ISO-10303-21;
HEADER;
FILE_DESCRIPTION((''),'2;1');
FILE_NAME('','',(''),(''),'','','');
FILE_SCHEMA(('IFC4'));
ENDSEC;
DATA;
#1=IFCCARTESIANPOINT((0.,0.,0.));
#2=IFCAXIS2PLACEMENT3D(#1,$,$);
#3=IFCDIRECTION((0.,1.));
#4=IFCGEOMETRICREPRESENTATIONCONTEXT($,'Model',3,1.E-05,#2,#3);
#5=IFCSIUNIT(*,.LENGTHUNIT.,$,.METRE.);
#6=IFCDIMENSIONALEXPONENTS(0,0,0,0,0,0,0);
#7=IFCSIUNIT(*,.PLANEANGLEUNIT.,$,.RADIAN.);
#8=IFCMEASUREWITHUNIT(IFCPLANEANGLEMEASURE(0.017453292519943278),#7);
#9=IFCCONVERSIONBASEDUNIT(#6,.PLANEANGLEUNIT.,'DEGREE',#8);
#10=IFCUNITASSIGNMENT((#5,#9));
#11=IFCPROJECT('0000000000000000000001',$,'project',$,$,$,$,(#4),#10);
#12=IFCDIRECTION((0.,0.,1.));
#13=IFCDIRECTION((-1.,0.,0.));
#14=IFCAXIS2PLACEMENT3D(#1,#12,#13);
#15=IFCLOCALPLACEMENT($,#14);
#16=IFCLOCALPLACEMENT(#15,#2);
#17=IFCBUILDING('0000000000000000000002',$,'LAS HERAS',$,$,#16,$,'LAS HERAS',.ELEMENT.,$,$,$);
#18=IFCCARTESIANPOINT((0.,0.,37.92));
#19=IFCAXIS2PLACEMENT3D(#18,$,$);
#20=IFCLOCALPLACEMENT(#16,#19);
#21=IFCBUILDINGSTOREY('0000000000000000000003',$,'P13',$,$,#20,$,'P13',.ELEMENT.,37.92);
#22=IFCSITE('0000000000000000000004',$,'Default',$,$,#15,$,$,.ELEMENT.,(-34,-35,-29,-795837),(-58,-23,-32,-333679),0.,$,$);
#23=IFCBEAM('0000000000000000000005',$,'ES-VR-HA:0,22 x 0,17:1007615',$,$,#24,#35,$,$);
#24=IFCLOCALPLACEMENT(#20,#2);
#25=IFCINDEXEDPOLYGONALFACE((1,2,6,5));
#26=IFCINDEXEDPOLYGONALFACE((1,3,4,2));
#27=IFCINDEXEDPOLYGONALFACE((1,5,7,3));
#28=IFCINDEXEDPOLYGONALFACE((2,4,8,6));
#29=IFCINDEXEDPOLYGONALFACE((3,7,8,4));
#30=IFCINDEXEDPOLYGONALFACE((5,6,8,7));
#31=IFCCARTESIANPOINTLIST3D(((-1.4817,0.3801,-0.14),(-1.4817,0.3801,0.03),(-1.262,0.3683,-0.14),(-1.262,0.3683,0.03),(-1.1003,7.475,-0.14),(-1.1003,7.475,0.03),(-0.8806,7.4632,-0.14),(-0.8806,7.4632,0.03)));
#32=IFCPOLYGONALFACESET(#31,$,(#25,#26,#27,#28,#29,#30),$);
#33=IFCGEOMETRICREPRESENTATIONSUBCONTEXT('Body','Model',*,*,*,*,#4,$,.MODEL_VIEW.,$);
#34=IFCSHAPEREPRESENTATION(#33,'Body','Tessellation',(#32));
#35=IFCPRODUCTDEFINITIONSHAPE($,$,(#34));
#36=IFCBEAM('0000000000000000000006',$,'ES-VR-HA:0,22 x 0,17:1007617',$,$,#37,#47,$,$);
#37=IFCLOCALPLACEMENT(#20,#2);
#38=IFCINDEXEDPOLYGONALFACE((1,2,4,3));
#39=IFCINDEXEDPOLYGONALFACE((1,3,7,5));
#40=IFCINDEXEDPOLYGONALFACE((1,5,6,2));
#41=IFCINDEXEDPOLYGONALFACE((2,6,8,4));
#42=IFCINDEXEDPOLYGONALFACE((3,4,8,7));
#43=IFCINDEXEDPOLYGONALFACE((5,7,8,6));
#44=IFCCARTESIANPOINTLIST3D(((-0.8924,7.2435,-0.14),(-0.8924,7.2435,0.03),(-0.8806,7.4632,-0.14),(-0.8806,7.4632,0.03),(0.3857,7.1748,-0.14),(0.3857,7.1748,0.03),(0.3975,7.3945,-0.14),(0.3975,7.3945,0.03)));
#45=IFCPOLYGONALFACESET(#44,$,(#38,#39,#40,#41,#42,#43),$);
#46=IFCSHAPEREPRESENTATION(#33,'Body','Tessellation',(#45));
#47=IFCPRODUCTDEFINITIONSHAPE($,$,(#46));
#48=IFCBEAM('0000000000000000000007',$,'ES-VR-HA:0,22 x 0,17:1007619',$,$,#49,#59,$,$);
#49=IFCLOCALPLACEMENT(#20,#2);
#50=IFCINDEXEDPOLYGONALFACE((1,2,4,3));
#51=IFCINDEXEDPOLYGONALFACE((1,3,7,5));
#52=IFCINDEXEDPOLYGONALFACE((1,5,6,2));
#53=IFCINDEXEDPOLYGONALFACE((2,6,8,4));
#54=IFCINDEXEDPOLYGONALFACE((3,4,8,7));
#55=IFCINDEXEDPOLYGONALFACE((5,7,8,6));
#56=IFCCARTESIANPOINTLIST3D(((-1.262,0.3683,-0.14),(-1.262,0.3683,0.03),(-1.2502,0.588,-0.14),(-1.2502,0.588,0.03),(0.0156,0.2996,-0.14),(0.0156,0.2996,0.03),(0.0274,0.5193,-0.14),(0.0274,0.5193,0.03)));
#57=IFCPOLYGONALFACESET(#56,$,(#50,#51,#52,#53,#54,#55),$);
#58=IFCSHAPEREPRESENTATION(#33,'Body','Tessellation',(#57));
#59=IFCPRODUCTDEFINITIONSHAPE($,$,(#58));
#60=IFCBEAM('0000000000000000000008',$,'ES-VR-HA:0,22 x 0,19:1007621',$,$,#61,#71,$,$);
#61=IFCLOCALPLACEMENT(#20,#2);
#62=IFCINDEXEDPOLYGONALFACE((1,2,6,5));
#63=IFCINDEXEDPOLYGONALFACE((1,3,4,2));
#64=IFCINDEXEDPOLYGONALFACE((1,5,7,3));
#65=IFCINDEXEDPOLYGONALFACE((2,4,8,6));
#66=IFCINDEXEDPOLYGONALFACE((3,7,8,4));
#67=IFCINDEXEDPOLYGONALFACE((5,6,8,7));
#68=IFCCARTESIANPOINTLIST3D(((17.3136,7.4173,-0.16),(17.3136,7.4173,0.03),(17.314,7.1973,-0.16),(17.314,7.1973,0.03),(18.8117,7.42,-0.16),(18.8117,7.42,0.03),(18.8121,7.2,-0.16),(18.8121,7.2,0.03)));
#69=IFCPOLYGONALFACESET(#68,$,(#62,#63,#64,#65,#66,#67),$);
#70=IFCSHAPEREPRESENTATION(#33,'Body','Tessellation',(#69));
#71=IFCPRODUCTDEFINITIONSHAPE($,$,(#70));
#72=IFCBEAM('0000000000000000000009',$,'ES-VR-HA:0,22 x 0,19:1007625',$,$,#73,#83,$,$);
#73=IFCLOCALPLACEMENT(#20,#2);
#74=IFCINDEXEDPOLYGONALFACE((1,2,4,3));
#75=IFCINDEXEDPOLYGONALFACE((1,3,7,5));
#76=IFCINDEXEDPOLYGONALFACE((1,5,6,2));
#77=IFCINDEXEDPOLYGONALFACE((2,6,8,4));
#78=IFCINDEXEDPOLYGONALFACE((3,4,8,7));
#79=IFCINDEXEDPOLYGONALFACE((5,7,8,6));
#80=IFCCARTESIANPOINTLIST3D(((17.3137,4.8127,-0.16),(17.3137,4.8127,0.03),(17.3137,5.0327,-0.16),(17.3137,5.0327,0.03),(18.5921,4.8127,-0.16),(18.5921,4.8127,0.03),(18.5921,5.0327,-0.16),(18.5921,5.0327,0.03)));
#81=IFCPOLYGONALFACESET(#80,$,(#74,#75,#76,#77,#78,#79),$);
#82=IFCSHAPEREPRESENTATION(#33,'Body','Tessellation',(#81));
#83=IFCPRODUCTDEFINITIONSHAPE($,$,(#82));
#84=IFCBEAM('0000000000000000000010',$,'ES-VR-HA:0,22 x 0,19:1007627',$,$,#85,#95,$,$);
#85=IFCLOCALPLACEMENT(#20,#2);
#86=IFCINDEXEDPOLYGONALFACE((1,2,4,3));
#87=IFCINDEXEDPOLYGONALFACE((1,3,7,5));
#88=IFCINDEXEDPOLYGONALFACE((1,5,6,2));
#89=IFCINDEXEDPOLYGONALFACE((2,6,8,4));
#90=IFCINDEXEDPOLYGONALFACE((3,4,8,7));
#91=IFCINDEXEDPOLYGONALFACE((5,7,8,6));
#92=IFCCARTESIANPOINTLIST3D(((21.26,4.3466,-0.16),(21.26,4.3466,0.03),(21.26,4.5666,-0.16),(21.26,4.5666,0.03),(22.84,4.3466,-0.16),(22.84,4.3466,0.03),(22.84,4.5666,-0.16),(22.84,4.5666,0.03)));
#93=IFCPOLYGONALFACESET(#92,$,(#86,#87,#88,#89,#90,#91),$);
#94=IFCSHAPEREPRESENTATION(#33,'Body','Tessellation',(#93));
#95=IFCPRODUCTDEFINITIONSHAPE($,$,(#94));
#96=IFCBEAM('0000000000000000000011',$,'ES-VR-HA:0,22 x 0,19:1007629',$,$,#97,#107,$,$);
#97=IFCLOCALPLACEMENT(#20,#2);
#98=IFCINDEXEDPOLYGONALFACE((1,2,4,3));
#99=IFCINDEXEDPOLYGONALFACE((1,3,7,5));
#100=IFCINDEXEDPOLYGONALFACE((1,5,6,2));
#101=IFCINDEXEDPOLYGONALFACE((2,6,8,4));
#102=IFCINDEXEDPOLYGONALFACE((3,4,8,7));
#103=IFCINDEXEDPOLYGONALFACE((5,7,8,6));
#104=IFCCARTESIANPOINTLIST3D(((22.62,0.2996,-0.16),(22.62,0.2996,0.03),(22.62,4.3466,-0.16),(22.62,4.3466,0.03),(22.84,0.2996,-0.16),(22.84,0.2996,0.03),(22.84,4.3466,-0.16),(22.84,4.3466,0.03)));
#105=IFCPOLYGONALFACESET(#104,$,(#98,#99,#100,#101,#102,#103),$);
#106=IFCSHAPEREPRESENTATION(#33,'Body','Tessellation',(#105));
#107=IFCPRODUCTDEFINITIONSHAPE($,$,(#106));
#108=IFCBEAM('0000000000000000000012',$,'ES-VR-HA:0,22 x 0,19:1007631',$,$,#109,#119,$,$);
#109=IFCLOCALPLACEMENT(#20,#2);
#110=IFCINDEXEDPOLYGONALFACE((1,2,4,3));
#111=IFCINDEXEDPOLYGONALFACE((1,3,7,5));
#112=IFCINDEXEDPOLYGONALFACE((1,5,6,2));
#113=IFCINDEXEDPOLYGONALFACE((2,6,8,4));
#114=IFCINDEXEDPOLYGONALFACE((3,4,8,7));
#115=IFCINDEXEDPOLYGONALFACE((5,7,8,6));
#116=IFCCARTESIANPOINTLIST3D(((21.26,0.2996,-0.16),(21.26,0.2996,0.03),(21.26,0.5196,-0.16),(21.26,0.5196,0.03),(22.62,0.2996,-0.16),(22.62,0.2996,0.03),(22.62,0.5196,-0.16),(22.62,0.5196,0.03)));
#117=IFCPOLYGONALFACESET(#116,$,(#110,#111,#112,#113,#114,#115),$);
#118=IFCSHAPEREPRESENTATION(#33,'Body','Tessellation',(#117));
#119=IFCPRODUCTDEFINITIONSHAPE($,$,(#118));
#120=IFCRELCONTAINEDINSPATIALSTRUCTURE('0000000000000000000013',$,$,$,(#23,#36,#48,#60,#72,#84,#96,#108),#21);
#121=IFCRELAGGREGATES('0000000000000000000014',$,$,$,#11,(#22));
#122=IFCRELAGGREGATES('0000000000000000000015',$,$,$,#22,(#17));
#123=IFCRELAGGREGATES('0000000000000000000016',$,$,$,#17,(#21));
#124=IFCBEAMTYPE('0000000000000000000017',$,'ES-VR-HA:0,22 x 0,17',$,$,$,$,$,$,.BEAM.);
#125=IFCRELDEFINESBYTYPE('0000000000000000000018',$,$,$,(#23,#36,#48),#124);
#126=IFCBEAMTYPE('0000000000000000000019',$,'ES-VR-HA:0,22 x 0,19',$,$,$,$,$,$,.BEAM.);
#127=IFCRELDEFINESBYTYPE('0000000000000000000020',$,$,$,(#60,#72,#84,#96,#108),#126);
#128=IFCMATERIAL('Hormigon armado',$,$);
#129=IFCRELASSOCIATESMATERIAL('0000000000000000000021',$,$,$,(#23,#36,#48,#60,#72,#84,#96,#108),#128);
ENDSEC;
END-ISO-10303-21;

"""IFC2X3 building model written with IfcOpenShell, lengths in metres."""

from ifc_helpers import new_model, entity, si_unit, converted_unit, direction, frame, frame_2d, origin, place, context, subcontext, project, spatial, rectangle, extrude, material, type_object, element, save


model = new_model("IFC2X3")

# Units and contexts
model_context = context("Model", 3, precision=1e-05, world=origin(), true_north=direction((0.0, 1.0)))
body_context = subcontext(model_context, "Body", "Model", "MODEL_VIEW")
ifc_project = project(units=[si_unit("LENGTHUNIT", "METRE"), converted_unit("PLANEANGLEUNIT", "DEGREE", entity("IfcPlaneAngleMeasure", 0.017453292519943278), si_unit("PLANEANGLEUNIT", "RADIAN"), dimensions=[0, 0, 0, 0, 0, 0, 0])], contexts=[model_context])

# Site, building, storey
site_placement = place(None, frame((0.0, 0.0, 0.0), z_axis=(0.0, 0.0, 1.0), x_axis=(-1.0, 0.0, 0.0)))
site = spatial("IfcSite", under=ifc_project, at=site_placement, Name="Default", CompositionType="ELEMENT", RefLatitude=(-34, -35, -29, -795837), RefLongitude=(-58, -23, -32, -333679), RefElevation=0.0)
building_placement = place(site_placement, origin())
building = spatial("IfcBuilding", under=site, at=building_placement, Name="LAS HERAS", LongName="LAS HERAS", CompositionType="ELEMENT")
storey_placement = place(building_placement, frame((0.0, 0.0, 37.92)))
storey = spatial("IfcBuildingStorey", under=building, at=storey_placement, Name="P13", LongName="P13", CompositionType="ELEMENT", Elevation=37.92)

# Beams
ifc_material = material(Name="Hormigon armado")
beam_type_1 = type_object("IfcBeamType", Name="ES-VR-HA:0,22 x 0,17", PredefinedType="BEAM")
beam_1_placement = place(storey_placement, frame((-0.9963, 7.3593, 0.03), z_axis=(0.0, 0.0, 1.0), x_axis=(-0.05369, -0.998558, 0.0)))
element("IfcBeam", 1, at=beam_1_placement, inside=storey, type_object=beam_type_1, material=ifc_material, Name="ES-VR-HA:0,22 x 0,17:1007615", context=body_context, shape_type="SweptSolid", body=[
    extrude(rectangle(XDim=0.17, YDim=0.22, at=frame_2d((0.0, 0.0), x_axis=(1.0, 0.0))), frame((-0.11, 0.0, -0.085), z_axis=(1.0, 0.0, 0.0), x_axis=(0.0, 0.0, -1.0)), (0.0, 0.0, 1.0), 7.1052),
])
beam_2_placement = place(storey_placement, frame((0.3916, 7.2846, 0.03), z_axis=(0.0, 0.0, 1.0), x_axis=(-0.998558, 0.05368, 0.0)))
element("IfcBeam", 2, at=beam_2_placement, inside=storey, type_object=beam_type_1, material=ifc_material, Name="ES-VR-HA:0,22 x 0,17:1007617", context=body_context, shape_type="SweptSolid", body=[
    extrude(rectangle(XDim=0.17, YDim=0.22, at=frame_2d((0.0, 0.0), x_axis=(1.0, 0.0))), frame((0.0, 0.0, -0.085), z_axis=(1.0, 0.0, 0.0), x_axis=(0.0, 0.0, -1.0)), (0.0, 0.0, 1.0), 1.28),
])
beam_3_placement = place(storey_placement, frame((0.0215, 0.4094, 0.03), z_axis=(0.0, 0.0, 1.0), x_axis=(-0.998558, 0.05369, 0.0)))
element("IfcBeam", 3, at=beam_3_placement, inside=storey, type_object=beam_type_1, material=ifc_material, Name="ES-VR-HA:0,22 x 0,17:1007619", context=body_context, shape_type="SweptSolid", body=[
    extrude(rectangle(XDim=0.17, YDim=0.22, at=frame_2d((0.0, 0.0), x_axis=(1.0, 0.0))), frame((0.0, 0.0, -0.085), z_axis=(1.0, 0.0, 0.0), x_axis=(0.0, 0.0, -1.0)), (0.0, 0.0, 1.0), 1.2795),
])
beam_type_2 = type_object("IfcBeamType", Name="ES-VR-HA:0,22 x 0,19", PredefinedType="BEAM")
beam_4_placement = place(storey_placement, frame((17.3138, 7.3073, 0.03), z_axis=(0.0, 0.0, 1.0), x_axis=(0.999998, 0.001781, 0.0)))
element("IfcBeam", 4, at=beam_4_placement, inside=storey, type_object=beam_type_2, material=ifc_material, Name="ES-VR-HA:0,22 x 0,19:1007621", context=body_context, shape_type="SweptSolid", body=[
    extrude(rectangle(XDim=0.19, YDim=0.22, at=frame_2d((0.0, 0.0), x_axis=(1.0, 0.0))), frame((0.0, 0.0, -0.095), z_axis=(1.0, 0.0, 0.0), x_axis=(0.0, 0.0, -1.0)), (0.0, 0.0, 1.0), 1.4981),
])
beam_5_placement = place(storey_placement, frame((17.3137, 4.9227, 0.03)))
element("IfcBeam", 5, at=beam_5_placement, inside=storey, type_object=beam_type_2, material=ifc_material, Name="ES-VR-HA:0,22 x 0,19:1007625", context=body_context, shape_type="SweptSolid", body=[
    extrude(rectangle(XDim=0.19, YDim=0.22, at=frame_2d((0.0, 0.0), x_axis=(1.0, 0.0))), frame((0.0, 0.0, -0.095), z_axis=(1.0, 0.0, 0.0), x_axis=(0.0, 0.0, -1.0)), (0.0, 0.0, 1.0), 1.2784),
])
beam_6_placement = place(storey_placement, frame((21.26, 4.4566, 0.03)))
element("IfcBeam", 6, at=beam_6_placement, inside=storey, type_object=beam_type_2, material=ifc_material, Name="ES-VR-HA:0,22 x 0,19:1007627", context=body_context, shape_type="SweptSolid", body=[
    extrude(rectangle(XDim=0.19, YDim=0.22, at=frame_2d((0.0, 0.0), x_axis=(1.0, 0.0))), frame((0.0, 0.0, -0.095), z_axis=(1.0, 0.0, 0.0), x_axis=(0.0, 0.0, -1.0)), (0.0, 0.0, 1.0), 1.58),
])
beam_7_placement = place(storey_placement, frame((22.73, 4.4566, 0.03), z_axis=(0.0, 0.0, 1.0), x_axis=(0.0, -1.0, 0.0)))
element("IfcBeam", 7, at=beam_7_placement, inside=storey, type_object=beam_type_2, material=ifc_material, Name="ES-VR-HA:0,22 x 0,19:1007629", context=body_context, shape_type="SweptSolid", body=[
    extrude(rectangle(XDim=0.19, YDim=0.22, at=frame_2d((0.0, 0.0), x_axis=(1.0, 0.0))), frame((0.11, 0.0, -0.095), z_axis=(1.0, 0.0, 0.0), x_axis=(0.0, 0.0, -1.0)), (0.0, 0.0, 1.0), 4.0471),
])
beam_8_placement = place(storey_placement, frame((21.26, 0.4096, 0.03)))
element("IfcBeam", 8, at=beam_8_placement, inside=storey, type_object=beam_type_2, material=ifc_material, Name="ES-VR-HA:0,22 x 0,19:1007631", context=body_context, shape_type="SweptSolid", body=[
    extrude(rectangle(XDim=0.19, YDim=0.22, at=frame_2d((0.0, 0.0), x_axis=(1.0, 0.0))), frame((0.0, 0.0, -0.095), z_axis=(1.0, 0.0, 0.0), x_axis=(0.0, 0.0, -1.0)), (0.0, 0.0, 1.0), 1.36),
])

save(model, "model.ifc")
